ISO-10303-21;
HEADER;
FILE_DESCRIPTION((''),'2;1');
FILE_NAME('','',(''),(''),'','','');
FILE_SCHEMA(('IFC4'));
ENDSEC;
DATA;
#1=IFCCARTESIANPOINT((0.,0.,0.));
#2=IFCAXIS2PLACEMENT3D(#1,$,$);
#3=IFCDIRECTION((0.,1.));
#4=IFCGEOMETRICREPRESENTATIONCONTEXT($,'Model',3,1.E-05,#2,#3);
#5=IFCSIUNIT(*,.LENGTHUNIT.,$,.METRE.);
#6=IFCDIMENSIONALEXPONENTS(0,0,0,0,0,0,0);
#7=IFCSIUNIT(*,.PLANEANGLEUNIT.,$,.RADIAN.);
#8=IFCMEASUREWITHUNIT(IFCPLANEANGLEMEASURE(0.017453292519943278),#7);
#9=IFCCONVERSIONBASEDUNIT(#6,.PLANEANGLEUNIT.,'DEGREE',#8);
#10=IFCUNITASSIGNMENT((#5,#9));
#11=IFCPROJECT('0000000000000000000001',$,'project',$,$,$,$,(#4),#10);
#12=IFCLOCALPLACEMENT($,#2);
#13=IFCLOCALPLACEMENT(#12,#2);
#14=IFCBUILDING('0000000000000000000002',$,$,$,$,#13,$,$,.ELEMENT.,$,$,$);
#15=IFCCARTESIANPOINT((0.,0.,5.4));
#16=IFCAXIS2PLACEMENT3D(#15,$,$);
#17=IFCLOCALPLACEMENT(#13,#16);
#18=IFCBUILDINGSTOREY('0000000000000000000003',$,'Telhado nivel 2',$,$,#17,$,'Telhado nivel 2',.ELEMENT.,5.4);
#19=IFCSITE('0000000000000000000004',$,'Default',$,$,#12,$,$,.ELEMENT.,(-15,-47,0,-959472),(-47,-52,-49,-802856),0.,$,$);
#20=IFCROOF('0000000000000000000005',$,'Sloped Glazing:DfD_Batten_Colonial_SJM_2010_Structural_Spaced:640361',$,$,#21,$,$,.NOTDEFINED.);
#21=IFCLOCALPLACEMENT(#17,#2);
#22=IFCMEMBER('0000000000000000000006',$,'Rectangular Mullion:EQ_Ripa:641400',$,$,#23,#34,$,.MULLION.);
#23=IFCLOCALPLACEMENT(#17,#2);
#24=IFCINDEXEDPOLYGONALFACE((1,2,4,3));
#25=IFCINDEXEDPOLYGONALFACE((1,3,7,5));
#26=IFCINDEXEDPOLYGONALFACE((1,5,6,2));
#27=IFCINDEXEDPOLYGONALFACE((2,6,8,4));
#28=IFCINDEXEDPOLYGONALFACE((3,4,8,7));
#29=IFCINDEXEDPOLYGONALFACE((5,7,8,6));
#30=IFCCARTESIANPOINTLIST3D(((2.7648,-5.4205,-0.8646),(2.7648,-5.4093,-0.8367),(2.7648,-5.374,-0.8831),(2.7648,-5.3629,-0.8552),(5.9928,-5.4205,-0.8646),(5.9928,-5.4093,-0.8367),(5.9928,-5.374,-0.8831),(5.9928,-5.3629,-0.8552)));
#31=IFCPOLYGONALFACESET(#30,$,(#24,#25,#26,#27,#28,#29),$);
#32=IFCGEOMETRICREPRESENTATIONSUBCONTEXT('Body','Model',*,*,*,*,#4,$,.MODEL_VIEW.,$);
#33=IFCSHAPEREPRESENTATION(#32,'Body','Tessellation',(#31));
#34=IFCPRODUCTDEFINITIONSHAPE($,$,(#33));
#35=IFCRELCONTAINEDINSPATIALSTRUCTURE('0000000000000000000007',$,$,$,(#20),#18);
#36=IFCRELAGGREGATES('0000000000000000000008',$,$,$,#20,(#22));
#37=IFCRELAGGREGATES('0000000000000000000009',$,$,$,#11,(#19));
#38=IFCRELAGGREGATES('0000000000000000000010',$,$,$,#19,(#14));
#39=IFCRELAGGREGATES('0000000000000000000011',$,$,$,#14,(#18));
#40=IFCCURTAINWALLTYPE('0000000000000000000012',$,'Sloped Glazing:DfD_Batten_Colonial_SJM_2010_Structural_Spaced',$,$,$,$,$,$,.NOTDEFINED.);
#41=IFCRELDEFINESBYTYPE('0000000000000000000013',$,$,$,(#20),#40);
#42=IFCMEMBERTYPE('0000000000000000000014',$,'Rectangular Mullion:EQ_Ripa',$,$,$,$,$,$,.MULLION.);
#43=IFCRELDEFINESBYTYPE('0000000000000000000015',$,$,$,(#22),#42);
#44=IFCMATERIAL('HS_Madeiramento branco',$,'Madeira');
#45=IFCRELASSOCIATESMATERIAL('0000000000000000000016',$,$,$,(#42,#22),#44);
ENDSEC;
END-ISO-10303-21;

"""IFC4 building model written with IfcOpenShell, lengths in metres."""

from ifc_helpers import new_model, entity, si_unit, converted_unit, direction, frame, origin, place, context, subcontext, project, spatial, indexed_curve, outline, extrude, source, transform, mapped, material, type_object, type_shapes, element, aggregate, save


model = new_model("IFC4")

# Units and contexts
model_context = context("Model", 3, precision=1e-05, world=origin(), true_north=direction((0.0, 1.0)))
body_context = subcontext(model_context, "Body", "Model", "MODEL_VIEW")
ifc_project = project(units=[si_unit("LENGTHUNIT", "METRE"), converted_unit("PLANEANGLEUNIT", "DEGREE", entity("IfcPlaneAngleMeasure", 0.017453292519943278), si_unit("PLANEANGLEUNIT", "RADIAN"), dimensions=[0, 0, 0, 0, 0, 0, 0])], contexts=[model_context])

# Site, building, storey
site_placement = place(None, origin())
site = spatial("IfcSite", under=ifc_project, at=site_placement, Name="Default", CompositionType="ELEMENT", RefLatitude=(-15, -47, 0, -959472), RefLongitude=(-47, -52, -49, -802856), RefElevation=0.0)
building_placement = place(site_placement, origin())
building = spatial("IfcBuilding", under=site, at=building_placement, CompositionType="ELEMENT")
storey_placement = place(building_placement, frame((0.0, 0.0, 5.4)))
storey = spatial("IfcBuildingStorey", under=building, at=storey_placement, Name="Telhado nivel 2", LongName="Telhado nivel 2", CompositionType="ELEMENT", Elevation=5.4)

# Roof, member
curtain_wall_type = type_object("IfcCurtainWallType", Name="Sloped Glazing:DfD_Batten_Colonial_SJM_2010_Structural_Spaced", PredefinedType="NOTDEFINED")
roof_placement = place(storey_placement, frame((0.0, 0.0, -5.4)))
roof = element("IfcRoof", 1, at=roof_placement, inside=storey, type_object=curtain_wall_type, Name="Sloped Glazing:DfD_Batten_Colonial_SJM_2010_Structural_Spaced:640361", PredefinedType="NOTDEFINED")
ifc_material = material(Name="HS_Madeiramento branco", Category="Madeira")
member_type_1 = type_object("IfcMemberType", Name="Rectangular Mullion:EQ_Ripa", PredefinedType="MULLION", material=ifc_material)
shared_shape_1 = source(origin(), body_context, "Body", "SweptSolid", [
    extrude(outline(indexed_curve([(-0.025, -0.015), (0.025, -0.015), (0.025, 0.015), (-0.025, 0.015), (-0.025, -0.015)], self_intersect=False)), frame((0.0, 0.0, -3.228), z_axis=(0.0, 0.0, 1.0), x_axis=(-1.0, 0.0, 0.0)), (0.0, 0.0, 1.0), 3.228),
])
type_shapes(member_type_1, [shared_shape_1])
member_1_placement = place(roof_placement, frame((5.9928, -5.3917, 4.5401), z_axis=(1.0, 0.0, 0.0), x_axis=(0.0, -0.928874, 0.370395)))
member_1 = element("IfcMember", 2, at=member_1_placement, type_object=member_type_1, material=ifc_material, Name="Rectangular Mullion:EQ_Ripa:641400", PredefinedType="MULLION", context=body_context, shape_type="MappedRepresentation", body=[
    mapped(shared_shape_1, transform((0.0, 0.0, 0.0), scale=1.0)),
])
aggregate(roof, [member_1])

save(model, "model.ifc")
